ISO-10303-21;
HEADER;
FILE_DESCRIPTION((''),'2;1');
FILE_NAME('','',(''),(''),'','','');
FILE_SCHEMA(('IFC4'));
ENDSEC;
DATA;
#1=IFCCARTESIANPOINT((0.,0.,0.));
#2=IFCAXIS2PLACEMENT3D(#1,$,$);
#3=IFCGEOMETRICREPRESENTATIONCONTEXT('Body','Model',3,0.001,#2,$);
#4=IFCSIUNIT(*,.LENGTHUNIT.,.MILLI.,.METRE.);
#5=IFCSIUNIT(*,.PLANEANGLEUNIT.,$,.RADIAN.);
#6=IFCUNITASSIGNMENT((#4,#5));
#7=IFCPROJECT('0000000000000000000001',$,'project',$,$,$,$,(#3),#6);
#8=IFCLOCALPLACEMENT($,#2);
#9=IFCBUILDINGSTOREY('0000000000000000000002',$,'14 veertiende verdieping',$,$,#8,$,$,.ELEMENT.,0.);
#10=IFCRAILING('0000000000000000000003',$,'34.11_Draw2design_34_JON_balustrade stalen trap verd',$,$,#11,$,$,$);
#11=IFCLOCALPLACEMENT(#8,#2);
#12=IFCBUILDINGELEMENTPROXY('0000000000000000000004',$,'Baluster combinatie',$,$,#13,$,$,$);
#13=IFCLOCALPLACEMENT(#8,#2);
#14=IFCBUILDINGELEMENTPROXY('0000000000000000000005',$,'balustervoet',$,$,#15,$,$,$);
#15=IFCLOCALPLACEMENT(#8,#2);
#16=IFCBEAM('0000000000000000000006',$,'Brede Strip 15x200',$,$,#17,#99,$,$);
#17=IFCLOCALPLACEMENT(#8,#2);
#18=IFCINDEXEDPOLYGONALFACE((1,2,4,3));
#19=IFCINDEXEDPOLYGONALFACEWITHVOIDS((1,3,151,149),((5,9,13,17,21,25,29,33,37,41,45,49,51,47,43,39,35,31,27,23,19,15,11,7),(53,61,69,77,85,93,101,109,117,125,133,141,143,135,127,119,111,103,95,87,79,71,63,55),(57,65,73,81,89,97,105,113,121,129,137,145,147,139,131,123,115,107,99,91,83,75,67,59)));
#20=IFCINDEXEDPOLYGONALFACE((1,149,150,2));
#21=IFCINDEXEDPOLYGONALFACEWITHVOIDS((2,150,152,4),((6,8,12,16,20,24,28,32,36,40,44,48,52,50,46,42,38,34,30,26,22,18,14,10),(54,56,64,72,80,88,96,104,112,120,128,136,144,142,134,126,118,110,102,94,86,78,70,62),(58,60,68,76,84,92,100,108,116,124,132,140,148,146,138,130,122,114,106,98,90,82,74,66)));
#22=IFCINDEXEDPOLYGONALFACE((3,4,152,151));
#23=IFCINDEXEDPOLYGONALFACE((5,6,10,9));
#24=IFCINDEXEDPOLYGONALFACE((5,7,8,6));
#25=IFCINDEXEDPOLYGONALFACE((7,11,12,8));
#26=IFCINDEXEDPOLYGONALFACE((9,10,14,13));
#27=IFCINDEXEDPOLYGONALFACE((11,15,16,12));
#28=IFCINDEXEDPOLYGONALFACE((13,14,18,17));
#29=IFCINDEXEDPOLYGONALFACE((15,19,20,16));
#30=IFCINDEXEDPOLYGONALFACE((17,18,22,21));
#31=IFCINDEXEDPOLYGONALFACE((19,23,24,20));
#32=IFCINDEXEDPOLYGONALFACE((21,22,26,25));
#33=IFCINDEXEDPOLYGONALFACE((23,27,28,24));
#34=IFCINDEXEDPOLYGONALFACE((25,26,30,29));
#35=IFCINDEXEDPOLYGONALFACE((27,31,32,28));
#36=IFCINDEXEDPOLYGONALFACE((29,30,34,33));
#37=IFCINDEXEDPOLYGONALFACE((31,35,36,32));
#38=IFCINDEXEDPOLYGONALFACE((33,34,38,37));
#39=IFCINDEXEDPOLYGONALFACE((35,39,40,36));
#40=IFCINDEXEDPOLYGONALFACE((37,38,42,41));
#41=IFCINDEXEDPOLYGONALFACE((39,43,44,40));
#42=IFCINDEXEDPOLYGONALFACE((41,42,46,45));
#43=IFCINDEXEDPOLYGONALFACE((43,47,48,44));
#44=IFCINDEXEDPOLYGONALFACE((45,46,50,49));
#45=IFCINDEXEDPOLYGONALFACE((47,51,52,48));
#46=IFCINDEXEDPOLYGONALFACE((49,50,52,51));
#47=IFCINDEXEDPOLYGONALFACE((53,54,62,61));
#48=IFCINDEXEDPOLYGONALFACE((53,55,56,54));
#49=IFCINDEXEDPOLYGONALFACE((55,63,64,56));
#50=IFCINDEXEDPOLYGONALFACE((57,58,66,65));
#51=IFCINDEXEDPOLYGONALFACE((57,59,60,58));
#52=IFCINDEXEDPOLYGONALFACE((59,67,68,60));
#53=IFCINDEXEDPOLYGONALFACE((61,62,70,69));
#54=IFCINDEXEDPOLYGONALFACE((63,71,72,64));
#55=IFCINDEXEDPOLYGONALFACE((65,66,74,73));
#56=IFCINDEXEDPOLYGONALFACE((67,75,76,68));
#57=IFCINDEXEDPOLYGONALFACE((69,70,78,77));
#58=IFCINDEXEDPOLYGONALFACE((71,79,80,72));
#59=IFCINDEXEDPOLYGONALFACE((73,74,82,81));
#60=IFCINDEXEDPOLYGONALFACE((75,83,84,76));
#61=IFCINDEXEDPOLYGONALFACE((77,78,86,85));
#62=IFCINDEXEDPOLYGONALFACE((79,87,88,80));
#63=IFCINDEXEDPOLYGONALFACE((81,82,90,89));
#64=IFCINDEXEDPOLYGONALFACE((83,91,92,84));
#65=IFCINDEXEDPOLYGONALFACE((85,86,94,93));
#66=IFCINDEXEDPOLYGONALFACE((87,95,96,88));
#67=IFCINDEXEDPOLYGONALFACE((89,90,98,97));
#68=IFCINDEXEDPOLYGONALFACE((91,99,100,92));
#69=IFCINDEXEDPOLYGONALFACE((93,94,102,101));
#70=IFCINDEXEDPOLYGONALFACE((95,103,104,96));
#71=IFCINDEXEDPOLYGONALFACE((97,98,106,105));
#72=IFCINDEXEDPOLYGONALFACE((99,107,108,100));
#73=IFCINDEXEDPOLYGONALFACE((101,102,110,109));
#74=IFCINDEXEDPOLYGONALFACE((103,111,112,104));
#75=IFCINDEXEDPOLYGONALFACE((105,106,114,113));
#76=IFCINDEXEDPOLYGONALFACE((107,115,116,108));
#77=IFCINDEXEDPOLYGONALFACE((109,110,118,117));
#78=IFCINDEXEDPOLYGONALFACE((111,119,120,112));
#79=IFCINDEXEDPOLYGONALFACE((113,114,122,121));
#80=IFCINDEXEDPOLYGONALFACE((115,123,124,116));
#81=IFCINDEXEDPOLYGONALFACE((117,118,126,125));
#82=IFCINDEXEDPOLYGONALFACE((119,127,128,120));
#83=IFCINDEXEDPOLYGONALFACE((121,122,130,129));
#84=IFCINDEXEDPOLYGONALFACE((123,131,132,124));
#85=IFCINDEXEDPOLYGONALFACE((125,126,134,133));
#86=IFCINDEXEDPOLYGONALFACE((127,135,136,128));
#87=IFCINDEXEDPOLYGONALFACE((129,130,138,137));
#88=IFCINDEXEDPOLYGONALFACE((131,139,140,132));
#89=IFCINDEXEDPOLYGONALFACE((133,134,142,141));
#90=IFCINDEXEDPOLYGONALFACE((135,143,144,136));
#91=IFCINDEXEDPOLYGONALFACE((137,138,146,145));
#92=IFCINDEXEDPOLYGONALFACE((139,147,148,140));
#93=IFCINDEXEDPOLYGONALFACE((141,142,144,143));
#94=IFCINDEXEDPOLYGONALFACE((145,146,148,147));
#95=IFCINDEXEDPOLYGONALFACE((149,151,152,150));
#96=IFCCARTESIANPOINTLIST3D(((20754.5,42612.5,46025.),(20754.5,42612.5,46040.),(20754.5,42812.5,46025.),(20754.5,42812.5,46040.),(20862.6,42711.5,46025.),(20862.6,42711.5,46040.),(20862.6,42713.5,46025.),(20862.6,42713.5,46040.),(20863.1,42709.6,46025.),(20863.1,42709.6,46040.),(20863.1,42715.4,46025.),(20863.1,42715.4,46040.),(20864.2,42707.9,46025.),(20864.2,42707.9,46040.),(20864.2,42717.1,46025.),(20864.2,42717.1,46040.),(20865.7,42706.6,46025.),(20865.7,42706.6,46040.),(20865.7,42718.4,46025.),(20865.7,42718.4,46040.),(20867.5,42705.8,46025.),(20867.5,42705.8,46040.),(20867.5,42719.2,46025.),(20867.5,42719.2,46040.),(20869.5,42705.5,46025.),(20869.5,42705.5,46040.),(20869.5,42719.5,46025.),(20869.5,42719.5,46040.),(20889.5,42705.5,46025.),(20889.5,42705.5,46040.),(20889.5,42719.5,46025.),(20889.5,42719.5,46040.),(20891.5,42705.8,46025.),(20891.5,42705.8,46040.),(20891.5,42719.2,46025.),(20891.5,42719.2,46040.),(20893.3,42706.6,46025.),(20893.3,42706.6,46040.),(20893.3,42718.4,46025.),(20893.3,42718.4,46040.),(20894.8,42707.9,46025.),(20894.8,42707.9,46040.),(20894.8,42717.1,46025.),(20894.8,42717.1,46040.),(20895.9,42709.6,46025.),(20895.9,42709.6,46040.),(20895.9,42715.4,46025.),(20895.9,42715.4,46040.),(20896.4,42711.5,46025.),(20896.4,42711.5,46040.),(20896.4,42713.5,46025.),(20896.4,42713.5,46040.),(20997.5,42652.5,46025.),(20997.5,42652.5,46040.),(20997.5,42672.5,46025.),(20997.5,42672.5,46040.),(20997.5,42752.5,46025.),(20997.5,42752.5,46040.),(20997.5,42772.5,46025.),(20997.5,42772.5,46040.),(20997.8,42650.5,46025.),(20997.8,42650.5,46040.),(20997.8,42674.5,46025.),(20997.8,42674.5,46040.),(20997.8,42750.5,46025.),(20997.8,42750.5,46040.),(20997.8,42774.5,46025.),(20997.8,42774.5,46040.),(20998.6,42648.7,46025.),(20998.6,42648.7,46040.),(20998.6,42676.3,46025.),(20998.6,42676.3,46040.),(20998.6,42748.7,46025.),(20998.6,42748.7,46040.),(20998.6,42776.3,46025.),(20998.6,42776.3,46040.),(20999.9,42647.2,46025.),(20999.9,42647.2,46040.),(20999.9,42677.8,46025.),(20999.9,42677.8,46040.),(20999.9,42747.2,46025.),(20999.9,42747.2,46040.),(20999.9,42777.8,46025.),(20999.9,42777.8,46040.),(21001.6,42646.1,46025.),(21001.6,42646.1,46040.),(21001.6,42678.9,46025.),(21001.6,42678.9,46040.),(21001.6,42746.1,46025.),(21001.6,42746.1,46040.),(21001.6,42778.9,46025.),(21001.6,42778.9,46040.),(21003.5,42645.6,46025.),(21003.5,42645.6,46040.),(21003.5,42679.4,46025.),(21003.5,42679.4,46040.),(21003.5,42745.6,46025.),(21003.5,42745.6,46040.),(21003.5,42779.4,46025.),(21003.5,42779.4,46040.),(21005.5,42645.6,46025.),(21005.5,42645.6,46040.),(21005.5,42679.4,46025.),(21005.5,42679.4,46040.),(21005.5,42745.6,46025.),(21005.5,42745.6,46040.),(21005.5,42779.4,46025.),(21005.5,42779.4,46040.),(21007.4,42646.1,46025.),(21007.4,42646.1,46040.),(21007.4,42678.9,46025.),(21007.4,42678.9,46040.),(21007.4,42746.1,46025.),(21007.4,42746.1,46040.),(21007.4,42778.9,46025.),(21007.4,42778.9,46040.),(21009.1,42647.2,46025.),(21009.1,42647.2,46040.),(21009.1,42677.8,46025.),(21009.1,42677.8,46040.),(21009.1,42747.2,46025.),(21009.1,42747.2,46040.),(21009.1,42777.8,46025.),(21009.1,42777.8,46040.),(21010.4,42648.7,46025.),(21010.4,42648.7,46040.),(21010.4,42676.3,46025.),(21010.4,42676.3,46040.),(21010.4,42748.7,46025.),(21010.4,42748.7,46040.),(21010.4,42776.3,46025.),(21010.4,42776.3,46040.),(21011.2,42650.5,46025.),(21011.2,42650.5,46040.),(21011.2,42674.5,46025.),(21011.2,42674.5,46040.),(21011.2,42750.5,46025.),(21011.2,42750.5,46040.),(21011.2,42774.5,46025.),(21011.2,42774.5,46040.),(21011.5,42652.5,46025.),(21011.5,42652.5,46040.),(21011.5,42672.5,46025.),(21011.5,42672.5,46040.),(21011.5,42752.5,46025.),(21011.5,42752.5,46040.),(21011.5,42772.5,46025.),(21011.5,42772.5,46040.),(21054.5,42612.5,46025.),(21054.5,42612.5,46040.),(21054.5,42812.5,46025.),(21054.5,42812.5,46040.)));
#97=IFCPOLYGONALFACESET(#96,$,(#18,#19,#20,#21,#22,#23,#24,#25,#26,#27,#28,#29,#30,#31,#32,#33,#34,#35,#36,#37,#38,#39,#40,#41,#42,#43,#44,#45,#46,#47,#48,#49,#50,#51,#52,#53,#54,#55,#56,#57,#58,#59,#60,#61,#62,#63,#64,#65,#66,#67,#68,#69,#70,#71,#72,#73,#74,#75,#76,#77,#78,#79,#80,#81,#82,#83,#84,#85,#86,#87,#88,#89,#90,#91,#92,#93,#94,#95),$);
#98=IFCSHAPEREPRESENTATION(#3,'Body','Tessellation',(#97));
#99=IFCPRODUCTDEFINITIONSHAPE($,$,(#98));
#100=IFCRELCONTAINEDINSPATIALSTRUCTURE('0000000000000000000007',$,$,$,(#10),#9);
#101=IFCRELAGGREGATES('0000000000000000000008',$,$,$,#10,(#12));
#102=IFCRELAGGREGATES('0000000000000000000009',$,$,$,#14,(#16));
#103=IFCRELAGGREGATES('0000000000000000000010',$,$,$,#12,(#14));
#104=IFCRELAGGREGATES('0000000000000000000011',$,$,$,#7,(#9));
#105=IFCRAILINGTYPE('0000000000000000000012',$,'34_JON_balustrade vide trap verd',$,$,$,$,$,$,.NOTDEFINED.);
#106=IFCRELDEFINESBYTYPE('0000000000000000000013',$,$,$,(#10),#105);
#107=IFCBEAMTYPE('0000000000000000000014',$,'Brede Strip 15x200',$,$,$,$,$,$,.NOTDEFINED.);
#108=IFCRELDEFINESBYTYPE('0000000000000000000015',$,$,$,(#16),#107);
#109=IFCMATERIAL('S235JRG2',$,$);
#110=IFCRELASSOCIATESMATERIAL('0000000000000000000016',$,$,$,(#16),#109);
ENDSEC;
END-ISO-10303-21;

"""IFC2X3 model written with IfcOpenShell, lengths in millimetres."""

from ifc_helpers import new_model, si_unit, point, frame, frame_2d, origin, origin_2d, place, context, project, spatial, circle_curve, line_curve, trimmed, segment, composite_curve, rectangle, outline, extrude, source, transform, mapped, material, type_object, element, aggregate, save


model = new_model("IFC2X3")

# Units and contexts
model_context = context("Model", 3, precision=0.001, world=origin(), identifier="Body")
ifc_project = project(units=[si_unit("LENGTHUNIT", "METRE", prefix="MILLI"), si_unit("PLANEANGLEUNIT", "RADIAN")], contexts=[model_context])

# Storey
storey_placement = place(None, origin())
storey = spatial("IfcBuildingStorey", under=ifc_project, at=storey_placement, Name="14 veertiende verdieping", CompositionType="ELEMENT", Elevation=0.0)

# Railing, building element proxies, beam, openings
railing_type = type_object("IfcRailingType", Name="34_JON_balustrade vide trap verd")
railing_placement = place(storey_placement, frame((-1939.6, -577.1, 100383.6)))
railing = element("IfcRailing", 1, at=railing_placement, inside=storey, type_object=railing_type, Name="34.11_Draw2design_34_JON_balustrade stalen trap verd")
proxy_1_placement = place(railing_placement, frame((24081.1, 45997.7, -55496.7), z_axis=(0.0, 0.0, 1.0), x_axis=(0.0, 1.0, 0.0)))
proxy_1 = element("IfcBuildingElementProxy", 2, at=proxy_1_placement, Name="Baluster combinatie")
aggregate(railing, [proxy_1])
proxy_2_placement = place(proxy_1_placement, frame((-47620.6, 22141.4, -48086.9), z_axis=(0.0, 0.0, 1.0), x_axis=(0.0, -1.0, 0.0)))
proxy_2 = element("IfcBuildingElementProxy", 3, at=proxy_2_placement, Name="balustervoet")
ifc_material_1 = material(Name="S235JRG2")
beam_type_1 = type_object("IfcBeamType", Name="Brede Strip 15x200")
shared_shape_1 = source(origin(), model_context, "Body", "SweptSolid", [
    extrude(rectangle(XDim=15.0, YDim=200.0, at=origin_2d()), origin(), (0.0, 0.0, -1.0), 300.0),
])
beam_1_placement = place(proxy_2_placement, frame((21054.5, 44912.5, 49232.5), z_axis=(1.0, 0.0, 0.0), x_axis=(0.0, 0.0, 1.0)))
beam_1 = element("IfcBeam", 4, at=beam_1_placement, type_object=beam_type_1, material=ifc_material_1, Name="Brede Strip 15x200", context=model_context, shape_type="MappedRepresentation", body=[
    mapped(shared_shape_1, transform((0.0, 0.0, 0.0), scale=1.0)),
])
opening_1_placement = place(beam_1_placement, frame((7.5, 0.0, -175.0), z_axis=(-1.0, 0.0, 0.0), x_axis=(0.0, 0.0, -1.0)))
element("IfcOpeningElement", 5, at=opening_1_placement, cuts=beam_1, ObjectType="Opening", context=model_context, shape_type="SweptSolid", body=[
    extrude(outline(composite_curve([segment(trimmed(circle_curve(frame_2d((10.0, 0.0), x_axis=(0.0, -1.0)), 7.0), [point((10.0, 7.0))], [point((10.0, -7.0))], False, "CARTESIAN"), True, "CONTINUOUS"), segment(trimmed(line_curve((10.0, -7.0), (-20.0, 0.0), 20.0), [point((10.0, -7.0))], [point((-10.0, -7.0))], True, "CARTESIAN"), True, "CONTINUOUS"), segment(trimmed(circle_curve(frame_2d((-10.0, 0.0), x_axis=(0.0, -1.0)), 7.0), [point((-10.0, -7.0))], [point((-10.0, 7.0))], False, "CARTESIAN"), True, "CONTINUOUS"), segment(trimmed(line_curve((-10.0, 7.0), (20.0, 0.0), 20.0), [point((-10.0, 7.0))], [point((10.0, 7.0))], True, "CARTESIAN"), True, "CONTINUOUS")], self_intersect=False)), origin(), (0.0, 0.0, 1.0), 15.0),
])
opening_2_placement = place(beam_1_placement, frame((7.5, -50.0, -50.0), z_axis=(-1.0, 0.0, 0.0), x_axis=(0.0, -1.0, 0.0)))
element("IfcOpeningElement", 6, at=opening_2_placement, cuts=beam_1, ObjectType="Opening", context=model_context, shape_type="SweptSolid", body=[
    extrude(outline(composite_curve([segment(trimmed(circle_curve(frame_2d((10.0, 0.0), x_axis=(0.0, -1.0)), 7.0), [point((10.0, 7.0))], [point((10.0, -7.0))], False, "CARTESIAN"), True, "CONTINUOUS"), segment(trimmed(line_curve((10.0, -7.0), (-20.0, 0.0), 20.0), [point((10.0, -7.0))], [point((-10.0, -7.0))], True, "CARTESIAN"), True, "CONTINUOUS"), segment(trimmed(circle_curve(frame_2d((-10.0, 0.0), x_axis=(0.0, -1.0)), 7.0), [point((-10.0, -7.0))], [point((-10.0, 7.0))], False, "CARTESIAN"), True, "CONTINUOUS"), segment(trimmed(line_curve((-10.0, 7.0), (20.0, 0.0), 20.0), [point((-10.0, 7.0))], [point((10.0, 7.0))], True, "CARTESIAN"), True, "CONTINUOUS")], self_intersect=False)), origin(), (0.0, 0.0, 1.0), 15.0),
])
opening_3_placement = place(beam_1_placement, frame((7.5, 50.0, -50.0), z_axis=(-1.0, 0.0, 0.0), x_axis=(0.0, -1.0, 0.0)))
element("IfcOpeningElement", 7, at=opening_3_placement, cuts=beam_1, ObjectType="Opening", context=model_context, shape_type="SweptSolid", body=[
    extrude(outline(composite_curve([segment(trimmed(circle_curve(frame_2d((10.0, 0.0), x_axis=(0.0, -1.0)), 7.0), [point((10.0, 7.0))], [point((10.0, -7.0))], False, "CARTESIAN"), True, "CONTINUOUS"), segment(trimmed(line_curve((10.0, -7.0), (-20.0, 0.0), 20.0), [point((10.0, -7.0))], [point((-10.0, -7.0))], True, "CARTESIAN"), True, "CONTINUOUS"), segment(trimmed(circle_curve(frame_2d((-10.0, 0.0), x_axis=(0.0, -1.0)), 7.0), [point((-10.0, -7.0))], [point((-10.0, 7.0))], False, "CARTESIAN"), True, "CONTINUOUS"), segment(trimmed(line_curve((-10.0, 7.0), (20.0, 0.0), 20.0), [point((-10.0, 7.0))], [point((10.0, 7.0))], True, "CARTESIAN"), True, "CONTINUOUS")], self_intersect=False)), origin(), (0.0, 0.0, 1.0), 15.0),
])
aggregate(proxy_2, [beam_1])
aggregate(proxy_1, [proxy_2])

save(model, "model.ifc")
